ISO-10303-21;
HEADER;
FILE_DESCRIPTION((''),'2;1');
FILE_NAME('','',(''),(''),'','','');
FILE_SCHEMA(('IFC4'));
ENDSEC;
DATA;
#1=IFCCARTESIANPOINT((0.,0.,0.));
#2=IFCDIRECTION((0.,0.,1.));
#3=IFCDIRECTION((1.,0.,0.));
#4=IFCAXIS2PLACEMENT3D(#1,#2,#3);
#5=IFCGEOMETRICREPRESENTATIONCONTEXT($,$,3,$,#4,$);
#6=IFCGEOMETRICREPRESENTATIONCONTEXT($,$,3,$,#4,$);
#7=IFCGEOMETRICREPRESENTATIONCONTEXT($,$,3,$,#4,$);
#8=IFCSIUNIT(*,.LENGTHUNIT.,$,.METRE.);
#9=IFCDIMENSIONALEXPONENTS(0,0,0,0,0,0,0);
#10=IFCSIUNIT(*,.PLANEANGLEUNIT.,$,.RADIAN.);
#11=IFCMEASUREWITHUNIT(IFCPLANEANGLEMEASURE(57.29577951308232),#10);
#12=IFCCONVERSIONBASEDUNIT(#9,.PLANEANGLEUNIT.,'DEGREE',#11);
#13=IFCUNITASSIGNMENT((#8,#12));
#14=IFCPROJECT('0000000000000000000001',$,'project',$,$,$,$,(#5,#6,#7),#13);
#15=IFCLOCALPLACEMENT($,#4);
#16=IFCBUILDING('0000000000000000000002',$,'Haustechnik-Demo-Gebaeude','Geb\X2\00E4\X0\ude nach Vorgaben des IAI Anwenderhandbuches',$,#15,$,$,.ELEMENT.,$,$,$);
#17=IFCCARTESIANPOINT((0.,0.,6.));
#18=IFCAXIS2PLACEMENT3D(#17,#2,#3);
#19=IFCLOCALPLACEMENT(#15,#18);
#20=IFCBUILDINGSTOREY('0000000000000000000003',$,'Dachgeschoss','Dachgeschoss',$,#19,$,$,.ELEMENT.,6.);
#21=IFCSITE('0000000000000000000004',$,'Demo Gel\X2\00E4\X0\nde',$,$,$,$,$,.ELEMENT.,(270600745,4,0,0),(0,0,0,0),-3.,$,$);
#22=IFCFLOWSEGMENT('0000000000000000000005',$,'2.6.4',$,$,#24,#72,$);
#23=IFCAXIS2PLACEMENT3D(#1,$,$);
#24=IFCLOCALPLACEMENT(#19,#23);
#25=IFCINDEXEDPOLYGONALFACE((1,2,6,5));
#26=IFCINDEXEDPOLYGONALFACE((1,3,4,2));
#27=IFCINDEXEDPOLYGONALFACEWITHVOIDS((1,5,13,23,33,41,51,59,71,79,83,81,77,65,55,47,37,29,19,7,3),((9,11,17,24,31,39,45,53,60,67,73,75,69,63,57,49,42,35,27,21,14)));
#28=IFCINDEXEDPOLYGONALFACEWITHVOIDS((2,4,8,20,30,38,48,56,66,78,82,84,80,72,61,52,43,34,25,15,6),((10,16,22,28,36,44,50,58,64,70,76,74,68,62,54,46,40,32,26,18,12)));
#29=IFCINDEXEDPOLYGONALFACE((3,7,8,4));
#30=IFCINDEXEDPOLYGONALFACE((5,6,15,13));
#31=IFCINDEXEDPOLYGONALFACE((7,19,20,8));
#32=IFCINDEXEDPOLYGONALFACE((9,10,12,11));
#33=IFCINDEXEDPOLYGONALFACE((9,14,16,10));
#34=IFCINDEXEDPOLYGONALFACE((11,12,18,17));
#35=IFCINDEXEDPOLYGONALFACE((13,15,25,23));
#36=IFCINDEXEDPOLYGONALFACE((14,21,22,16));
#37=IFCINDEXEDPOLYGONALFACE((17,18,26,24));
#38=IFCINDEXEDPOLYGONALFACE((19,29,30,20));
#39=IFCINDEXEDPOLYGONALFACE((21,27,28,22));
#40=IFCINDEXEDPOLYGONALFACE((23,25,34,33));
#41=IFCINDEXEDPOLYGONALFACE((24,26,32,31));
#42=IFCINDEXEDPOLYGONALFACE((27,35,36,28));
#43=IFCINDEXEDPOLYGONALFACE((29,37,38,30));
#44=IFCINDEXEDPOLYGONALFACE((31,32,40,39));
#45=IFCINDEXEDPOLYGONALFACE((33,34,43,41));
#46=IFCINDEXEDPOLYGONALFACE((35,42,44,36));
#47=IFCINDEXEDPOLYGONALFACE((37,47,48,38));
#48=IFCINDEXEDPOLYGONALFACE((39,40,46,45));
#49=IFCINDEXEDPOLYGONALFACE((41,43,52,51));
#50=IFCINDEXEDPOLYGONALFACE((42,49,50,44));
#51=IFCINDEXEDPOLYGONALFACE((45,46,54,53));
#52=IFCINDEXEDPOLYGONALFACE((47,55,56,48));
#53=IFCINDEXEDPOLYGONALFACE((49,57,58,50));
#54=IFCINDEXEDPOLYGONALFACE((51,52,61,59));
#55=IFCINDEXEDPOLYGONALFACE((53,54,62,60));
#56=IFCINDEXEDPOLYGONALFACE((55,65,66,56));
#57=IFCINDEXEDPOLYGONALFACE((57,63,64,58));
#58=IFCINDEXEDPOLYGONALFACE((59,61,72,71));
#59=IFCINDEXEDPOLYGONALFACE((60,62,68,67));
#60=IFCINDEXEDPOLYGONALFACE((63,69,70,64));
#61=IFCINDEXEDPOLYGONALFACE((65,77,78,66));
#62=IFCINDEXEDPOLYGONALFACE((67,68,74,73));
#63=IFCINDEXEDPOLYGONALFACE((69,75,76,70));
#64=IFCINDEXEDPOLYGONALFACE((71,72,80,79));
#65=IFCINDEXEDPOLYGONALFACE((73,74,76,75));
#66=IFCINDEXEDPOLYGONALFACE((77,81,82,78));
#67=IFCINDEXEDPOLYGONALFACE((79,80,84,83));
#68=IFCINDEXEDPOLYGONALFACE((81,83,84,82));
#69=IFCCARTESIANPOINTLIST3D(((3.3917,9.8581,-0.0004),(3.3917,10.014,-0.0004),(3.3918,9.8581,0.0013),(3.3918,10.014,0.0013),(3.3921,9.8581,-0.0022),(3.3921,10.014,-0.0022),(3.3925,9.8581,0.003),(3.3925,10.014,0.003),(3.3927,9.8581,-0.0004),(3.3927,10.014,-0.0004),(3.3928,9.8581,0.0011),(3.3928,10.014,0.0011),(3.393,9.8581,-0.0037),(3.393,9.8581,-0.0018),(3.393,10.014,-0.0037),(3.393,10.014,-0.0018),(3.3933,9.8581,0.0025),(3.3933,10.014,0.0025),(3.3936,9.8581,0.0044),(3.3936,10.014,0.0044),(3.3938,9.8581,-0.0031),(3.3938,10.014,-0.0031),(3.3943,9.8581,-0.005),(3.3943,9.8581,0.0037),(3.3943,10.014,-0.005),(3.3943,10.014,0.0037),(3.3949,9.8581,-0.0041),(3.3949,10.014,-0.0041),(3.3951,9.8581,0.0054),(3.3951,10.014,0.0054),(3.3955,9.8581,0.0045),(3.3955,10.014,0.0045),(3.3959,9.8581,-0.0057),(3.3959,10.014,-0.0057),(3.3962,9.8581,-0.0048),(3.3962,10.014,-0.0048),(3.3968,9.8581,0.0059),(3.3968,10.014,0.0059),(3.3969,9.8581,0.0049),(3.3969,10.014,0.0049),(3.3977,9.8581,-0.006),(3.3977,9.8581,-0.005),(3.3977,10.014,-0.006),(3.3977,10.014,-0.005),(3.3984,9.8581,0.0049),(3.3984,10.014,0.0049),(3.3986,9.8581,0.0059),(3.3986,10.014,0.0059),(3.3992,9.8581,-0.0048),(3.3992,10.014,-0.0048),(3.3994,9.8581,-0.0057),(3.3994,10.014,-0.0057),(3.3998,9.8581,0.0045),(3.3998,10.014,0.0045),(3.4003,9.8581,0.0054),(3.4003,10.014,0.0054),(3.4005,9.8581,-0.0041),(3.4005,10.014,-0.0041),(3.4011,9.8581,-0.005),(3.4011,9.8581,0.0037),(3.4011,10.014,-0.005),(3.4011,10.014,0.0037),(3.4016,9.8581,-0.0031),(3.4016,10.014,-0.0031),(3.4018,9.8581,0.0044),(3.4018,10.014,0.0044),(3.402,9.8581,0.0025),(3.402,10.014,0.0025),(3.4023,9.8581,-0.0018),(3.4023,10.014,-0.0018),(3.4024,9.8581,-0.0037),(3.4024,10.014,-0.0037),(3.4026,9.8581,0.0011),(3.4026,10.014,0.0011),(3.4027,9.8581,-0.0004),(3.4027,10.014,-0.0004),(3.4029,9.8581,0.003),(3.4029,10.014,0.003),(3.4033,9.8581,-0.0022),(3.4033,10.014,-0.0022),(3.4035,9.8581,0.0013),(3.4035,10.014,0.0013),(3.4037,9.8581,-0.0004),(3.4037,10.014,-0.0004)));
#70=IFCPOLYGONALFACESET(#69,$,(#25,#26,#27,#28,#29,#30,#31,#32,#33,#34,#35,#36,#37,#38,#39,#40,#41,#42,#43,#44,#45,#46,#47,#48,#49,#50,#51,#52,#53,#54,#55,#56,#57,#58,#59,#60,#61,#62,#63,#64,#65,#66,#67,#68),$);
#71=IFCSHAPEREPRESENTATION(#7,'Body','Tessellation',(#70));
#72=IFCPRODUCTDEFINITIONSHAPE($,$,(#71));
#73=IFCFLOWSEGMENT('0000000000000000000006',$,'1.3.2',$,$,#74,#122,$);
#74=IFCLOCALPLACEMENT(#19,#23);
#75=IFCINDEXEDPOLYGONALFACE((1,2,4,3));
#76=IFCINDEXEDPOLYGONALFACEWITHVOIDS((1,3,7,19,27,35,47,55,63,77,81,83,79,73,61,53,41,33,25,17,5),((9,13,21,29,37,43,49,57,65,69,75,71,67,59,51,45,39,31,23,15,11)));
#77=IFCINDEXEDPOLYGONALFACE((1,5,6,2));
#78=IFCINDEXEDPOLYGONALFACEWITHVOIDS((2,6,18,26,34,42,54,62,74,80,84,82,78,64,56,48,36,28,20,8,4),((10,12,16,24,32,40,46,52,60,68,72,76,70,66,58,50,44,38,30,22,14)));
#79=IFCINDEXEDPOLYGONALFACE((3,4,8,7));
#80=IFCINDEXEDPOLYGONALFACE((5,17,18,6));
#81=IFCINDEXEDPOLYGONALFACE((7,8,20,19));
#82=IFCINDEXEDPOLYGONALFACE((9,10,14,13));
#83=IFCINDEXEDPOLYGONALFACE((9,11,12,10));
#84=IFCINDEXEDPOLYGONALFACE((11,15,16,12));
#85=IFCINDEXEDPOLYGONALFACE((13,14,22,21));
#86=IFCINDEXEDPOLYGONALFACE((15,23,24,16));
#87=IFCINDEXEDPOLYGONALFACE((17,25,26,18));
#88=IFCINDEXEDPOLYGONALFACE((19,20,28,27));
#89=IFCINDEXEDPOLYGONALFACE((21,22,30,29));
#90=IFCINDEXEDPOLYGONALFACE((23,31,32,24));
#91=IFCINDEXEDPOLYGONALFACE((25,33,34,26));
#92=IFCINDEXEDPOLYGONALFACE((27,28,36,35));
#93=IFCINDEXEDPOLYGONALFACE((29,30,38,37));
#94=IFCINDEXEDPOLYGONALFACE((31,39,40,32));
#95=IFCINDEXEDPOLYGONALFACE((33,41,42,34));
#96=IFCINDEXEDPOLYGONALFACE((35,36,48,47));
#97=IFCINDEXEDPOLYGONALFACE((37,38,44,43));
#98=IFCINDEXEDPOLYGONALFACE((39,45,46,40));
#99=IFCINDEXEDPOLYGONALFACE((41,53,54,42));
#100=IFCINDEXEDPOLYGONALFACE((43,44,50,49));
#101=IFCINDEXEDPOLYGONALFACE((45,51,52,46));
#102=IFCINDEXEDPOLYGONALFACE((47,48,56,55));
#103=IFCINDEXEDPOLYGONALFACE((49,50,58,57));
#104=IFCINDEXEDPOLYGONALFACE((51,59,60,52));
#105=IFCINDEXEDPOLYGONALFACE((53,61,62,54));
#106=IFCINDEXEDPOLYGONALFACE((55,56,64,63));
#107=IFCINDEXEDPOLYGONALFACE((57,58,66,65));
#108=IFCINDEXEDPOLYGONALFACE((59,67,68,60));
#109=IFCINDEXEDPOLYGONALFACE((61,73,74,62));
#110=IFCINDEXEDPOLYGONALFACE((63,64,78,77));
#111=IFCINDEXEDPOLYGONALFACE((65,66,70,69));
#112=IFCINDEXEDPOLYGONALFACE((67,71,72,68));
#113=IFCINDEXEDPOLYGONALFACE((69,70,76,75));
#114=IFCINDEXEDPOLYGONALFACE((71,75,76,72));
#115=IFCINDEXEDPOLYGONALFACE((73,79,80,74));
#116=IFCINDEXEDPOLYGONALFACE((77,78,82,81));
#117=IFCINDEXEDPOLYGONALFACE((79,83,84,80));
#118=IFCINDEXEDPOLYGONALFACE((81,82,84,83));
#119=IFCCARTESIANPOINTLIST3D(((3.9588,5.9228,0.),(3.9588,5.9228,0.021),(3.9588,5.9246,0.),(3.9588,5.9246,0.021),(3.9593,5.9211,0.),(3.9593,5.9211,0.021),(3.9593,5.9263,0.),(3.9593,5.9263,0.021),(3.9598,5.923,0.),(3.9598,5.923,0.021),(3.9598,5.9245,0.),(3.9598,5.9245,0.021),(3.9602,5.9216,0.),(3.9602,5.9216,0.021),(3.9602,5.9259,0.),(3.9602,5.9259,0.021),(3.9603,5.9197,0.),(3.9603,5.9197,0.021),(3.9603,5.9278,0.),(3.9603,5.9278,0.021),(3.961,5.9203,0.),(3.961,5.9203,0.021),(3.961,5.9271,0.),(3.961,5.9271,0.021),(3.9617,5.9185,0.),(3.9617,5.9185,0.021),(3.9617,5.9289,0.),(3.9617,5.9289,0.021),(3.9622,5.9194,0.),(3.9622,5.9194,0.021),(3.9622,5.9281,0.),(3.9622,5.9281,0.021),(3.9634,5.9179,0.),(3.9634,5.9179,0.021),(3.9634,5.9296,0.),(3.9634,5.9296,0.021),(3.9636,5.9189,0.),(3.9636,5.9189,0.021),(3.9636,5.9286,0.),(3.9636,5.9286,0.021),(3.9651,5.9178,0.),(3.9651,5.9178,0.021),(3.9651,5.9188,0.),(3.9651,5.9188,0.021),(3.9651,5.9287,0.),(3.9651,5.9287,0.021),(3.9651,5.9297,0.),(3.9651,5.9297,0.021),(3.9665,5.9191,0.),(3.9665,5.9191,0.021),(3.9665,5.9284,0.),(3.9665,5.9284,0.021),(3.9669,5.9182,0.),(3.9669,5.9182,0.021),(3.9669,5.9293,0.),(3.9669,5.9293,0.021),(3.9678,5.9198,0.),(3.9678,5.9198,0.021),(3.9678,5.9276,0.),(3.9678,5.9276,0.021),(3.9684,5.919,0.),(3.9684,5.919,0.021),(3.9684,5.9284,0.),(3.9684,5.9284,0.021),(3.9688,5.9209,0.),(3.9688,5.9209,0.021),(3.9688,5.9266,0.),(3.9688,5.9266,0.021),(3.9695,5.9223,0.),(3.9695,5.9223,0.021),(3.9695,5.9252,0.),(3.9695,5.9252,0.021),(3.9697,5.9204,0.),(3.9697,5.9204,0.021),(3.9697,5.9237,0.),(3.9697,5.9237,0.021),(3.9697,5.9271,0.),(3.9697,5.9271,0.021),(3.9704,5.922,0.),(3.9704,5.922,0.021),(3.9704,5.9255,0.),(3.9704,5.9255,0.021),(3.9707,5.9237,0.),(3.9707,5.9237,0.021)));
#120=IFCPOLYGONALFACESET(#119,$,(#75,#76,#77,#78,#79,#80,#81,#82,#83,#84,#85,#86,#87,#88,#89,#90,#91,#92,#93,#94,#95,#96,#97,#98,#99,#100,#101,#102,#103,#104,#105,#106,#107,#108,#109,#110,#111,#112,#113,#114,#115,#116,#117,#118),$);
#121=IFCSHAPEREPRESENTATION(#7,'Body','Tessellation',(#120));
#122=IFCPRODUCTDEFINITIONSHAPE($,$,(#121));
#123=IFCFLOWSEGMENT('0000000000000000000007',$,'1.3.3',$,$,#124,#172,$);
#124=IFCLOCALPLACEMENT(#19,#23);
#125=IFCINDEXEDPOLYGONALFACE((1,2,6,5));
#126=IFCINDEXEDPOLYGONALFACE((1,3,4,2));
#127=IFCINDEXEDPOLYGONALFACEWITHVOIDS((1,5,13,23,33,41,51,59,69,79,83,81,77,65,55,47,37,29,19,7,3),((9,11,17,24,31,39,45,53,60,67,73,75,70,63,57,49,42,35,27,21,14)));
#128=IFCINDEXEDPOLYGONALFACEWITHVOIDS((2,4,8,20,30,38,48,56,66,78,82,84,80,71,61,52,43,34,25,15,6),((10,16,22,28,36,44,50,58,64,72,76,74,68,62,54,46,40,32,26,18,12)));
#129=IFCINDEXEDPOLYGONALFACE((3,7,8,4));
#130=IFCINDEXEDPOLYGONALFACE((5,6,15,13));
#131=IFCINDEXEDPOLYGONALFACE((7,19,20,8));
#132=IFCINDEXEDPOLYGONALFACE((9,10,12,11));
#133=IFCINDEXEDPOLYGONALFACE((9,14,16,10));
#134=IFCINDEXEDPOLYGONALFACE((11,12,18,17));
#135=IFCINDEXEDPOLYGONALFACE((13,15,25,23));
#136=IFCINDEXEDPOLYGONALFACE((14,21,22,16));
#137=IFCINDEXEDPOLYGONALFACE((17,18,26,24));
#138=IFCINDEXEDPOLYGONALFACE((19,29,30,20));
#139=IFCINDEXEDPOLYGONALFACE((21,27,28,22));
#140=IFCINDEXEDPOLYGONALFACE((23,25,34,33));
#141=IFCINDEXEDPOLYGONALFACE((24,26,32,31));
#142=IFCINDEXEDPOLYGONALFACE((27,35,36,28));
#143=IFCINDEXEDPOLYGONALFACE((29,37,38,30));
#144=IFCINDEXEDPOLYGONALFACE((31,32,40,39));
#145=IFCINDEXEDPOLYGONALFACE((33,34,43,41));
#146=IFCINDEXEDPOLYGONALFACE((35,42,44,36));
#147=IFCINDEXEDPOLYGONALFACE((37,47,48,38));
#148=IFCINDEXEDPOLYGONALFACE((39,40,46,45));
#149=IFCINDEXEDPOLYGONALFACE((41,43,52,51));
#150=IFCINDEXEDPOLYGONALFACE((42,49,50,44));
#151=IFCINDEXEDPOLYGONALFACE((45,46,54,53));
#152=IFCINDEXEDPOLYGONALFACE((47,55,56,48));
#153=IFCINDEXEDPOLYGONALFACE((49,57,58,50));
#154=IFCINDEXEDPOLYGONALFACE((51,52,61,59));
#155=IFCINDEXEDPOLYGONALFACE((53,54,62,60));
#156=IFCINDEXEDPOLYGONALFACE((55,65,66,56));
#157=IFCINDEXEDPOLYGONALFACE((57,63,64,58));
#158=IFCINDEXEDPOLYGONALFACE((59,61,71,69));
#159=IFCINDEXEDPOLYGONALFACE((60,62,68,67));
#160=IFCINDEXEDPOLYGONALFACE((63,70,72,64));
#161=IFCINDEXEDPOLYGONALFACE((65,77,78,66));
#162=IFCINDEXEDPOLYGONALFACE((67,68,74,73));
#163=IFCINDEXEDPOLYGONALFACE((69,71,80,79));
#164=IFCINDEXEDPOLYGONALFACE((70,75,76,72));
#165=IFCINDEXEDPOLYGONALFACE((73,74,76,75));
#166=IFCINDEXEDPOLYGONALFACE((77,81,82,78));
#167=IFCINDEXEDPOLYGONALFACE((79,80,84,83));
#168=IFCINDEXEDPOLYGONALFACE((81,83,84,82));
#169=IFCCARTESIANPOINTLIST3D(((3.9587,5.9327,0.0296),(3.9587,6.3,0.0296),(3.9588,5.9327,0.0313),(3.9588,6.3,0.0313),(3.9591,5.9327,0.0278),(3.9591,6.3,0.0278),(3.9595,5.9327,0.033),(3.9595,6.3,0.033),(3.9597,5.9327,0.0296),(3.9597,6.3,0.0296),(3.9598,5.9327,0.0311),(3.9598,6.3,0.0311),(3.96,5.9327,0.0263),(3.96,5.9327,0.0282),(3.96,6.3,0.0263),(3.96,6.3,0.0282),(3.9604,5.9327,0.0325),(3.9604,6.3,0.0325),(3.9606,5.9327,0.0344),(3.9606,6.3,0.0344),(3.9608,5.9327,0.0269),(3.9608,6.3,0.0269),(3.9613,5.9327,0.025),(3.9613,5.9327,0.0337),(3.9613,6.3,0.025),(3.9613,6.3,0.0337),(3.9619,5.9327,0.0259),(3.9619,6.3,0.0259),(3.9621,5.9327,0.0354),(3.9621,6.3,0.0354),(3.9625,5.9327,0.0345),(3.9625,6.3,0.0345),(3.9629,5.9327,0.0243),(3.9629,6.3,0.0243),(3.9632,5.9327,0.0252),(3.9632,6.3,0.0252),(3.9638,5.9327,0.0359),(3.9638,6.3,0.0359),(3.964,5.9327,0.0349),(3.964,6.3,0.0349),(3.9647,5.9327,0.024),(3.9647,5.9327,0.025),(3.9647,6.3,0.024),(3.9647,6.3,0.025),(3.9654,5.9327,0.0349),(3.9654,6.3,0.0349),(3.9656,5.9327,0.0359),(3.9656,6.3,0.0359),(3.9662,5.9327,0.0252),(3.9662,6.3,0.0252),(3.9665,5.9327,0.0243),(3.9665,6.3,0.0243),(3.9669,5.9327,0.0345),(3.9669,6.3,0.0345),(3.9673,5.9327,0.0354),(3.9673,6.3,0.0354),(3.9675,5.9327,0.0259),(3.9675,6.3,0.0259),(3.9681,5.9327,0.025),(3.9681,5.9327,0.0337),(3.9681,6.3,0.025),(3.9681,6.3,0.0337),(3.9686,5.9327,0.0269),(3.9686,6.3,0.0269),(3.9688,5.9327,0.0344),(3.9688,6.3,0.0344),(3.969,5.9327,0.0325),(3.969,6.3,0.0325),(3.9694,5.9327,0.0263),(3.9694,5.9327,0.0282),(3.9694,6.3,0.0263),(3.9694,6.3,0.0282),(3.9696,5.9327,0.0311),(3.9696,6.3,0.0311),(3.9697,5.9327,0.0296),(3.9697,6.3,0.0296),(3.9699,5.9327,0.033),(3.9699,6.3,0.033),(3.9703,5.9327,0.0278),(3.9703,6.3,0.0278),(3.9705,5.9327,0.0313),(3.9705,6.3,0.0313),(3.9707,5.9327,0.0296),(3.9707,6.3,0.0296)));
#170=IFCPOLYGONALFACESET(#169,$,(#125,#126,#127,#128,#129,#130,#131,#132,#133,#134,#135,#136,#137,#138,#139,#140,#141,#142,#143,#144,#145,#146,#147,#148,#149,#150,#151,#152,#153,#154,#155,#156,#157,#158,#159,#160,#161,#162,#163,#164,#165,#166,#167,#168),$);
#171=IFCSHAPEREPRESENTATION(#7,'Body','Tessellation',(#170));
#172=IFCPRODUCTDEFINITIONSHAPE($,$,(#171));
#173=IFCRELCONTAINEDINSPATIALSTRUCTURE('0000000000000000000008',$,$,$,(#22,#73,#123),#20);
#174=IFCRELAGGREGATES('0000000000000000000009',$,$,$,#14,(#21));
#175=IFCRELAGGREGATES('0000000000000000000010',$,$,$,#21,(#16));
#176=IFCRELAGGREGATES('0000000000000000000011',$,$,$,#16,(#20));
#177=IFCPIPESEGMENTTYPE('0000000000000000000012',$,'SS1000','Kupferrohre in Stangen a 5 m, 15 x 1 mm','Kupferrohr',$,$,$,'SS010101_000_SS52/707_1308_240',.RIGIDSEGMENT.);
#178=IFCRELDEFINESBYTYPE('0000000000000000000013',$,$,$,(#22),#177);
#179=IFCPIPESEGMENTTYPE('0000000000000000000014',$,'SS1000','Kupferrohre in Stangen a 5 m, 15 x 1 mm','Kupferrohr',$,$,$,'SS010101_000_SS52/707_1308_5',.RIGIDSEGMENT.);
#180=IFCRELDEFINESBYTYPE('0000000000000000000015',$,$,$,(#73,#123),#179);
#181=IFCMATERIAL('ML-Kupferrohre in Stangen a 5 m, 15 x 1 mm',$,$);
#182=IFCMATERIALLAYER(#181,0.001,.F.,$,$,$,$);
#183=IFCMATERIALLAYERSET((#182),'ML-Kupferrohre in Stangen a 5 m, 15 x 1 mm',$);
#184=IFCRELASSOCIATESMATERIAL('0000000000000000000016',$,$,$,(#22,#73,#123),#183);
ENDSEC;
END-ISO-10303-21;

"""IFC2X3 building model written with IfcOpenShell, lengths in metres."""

from ifc_helpers import new_model, entity, si_unit, converted_unit, frame, origin_with_axes, origin_2d_with_axis, place, context, project, spatial, hollow_circle, extrude, material, layer, layer_set, layer_usage, type_object, element, save


model = new_model("IFC2X3")

# Units and contexts
context_of_model_1 = context(None, 3, world=origin_with_axes())
context_of_model_2 = context(None, 3, world=origin_with_axes())
context_of_model_3 = context(None, 3, world=origin_with_axes())
ifc_project = project(units=[si_unit("LENGTHUNIT", "METRE"), converted_unit("PLANEANGLEUNIT", "DEGREE", entity("IfcPlaneAngleMeasure", 57.29577951308232), si_unit("PLANEANGLEUNIT", "RADIAN"), dimensions=[0, 0, 0, 0, 0, 0, 0])], contexts=[context_of_model_1, context_of_model_2, context_of_model_3])

# Site, building, storey
site = spatial("IfcSite", under=ifc_project, Name="Demo Gelände", CompositionType="ELEMENT", RefLatitude=(270600745, 4, 0, 0), RefLongitude=(0, 0, 0, 0), RefElevation=-3.0)
building_placement = place(None, origin_with_axes())
building = spatial("IfcBuilding", under=site, at=building_placement, Name="Haustechnik-Demo-Gebaeude", Description="Gebäude nach Vorgaben des IAI Anwenderhandbuches", CompositionType="ELEMENT")
storey_placement = place(building_placement, frame((0.0, 0.0, 6.0), z_axis=(0.0, 0.0, 1.0), x_axis=(1.0, 0.0, 0.0)))
storey = spatial("IfcBuildingStorey", under=building, at=storey_placement, Name="Dachgeschoss", Description="Dachgeschoss", CompositionType="ELEMENT", Elevation=6.0)

# Flow segments
ifc_material = material(Name="ML-Kupferrohre in Stangen a 5 m, 15 x 1 mm")
ifc_layer = layer(ifc_material, 0.001, ventilated=False)
ifc_layer_set = layer_set([ifc_layer], Name="ML-Kupferrohre in Stangen a 5 m, 15 x 1 mm")
ifc_layer_usage = layer_usage(ifc_layer_set, "AXIS2", "POSITIVE", 0.0)
pipe_segment_type_1 = type_object("IfcPipeSegmentType", Name="SS1000", Description="Kupferrohre in Stangen a 5 m, 15 x 1 mm", ApplicableOccurrence="Kupferrohr", ElementType="SS010101_000_SS52/707_1308_240", PredefinedType="RIGIDSEGMENT")
flow_segment_1_placement = place(storey_placement, frame((3.3977, 10.014, 0.0), z_axis=(0.000021, -1.0, 0.0), x_axis=(0.0, 0.0, -1.0)))
element("IfcFlowSegment", 1, at=flow_segment_1_placement, inside=storey, type_object=pipe_segment_type_1, material=ifc_layer_usage, Name="2.6.4", context=context_of_model_3, shape_type="SweptSolid", body=[
    extrude(hollow_circle(Radius=0.006, WallThickness=0.001, at=origin_2d_with_axis()), origin_with_axes(), (0.0, 0.0, 1.0), 0.1559),
])
pipe_segment_type_2 = type_object("IfcPipeSegmentType", Name="SS1000", Description="Kupferrohre in Stangen a 5 m, 15 x 1 mm", ApplicableOccurrence="Kupferrohr", ElementType="SS010101_000_SS52/707_1308_5", PredefinedType="RIGIDSEGMENT")
flow_segment_2_placement = place(storey_placement, frame((3.9647, 5.9237, 0.0), z_axis=(0.0, 0.0, 1.0), x_axis=(1.0, 0.0, 0.0)))
element("IfcFlowSegment", 2, at=flow_segment_2_placement, inside=storey, type_object=pipe_segment_type_2, material=ifc_layer_usage, Name="1.3.2", context=context_of_model_3, shape_type="SweptSolid", body=[
    extrude(hollow_circle(Radius=0.006, WallThickness=0.001, at=origin_2d_with_axis()), origin_with_axes(), (0.0, 0.0, 1.0), 0.021),
])
flow_segment_3_placement = place(storey_placement, frame((3.9647, 5.9327, 0.03), z_axis=(0.0, 1.0, 0.0), x_axis=(0.0, 0.0, -1.0)))
element("IfcFlowSegment", 3, at=flow_segment_3_placement, inside=storey, type_object=pipe_segment_type_2, material=ifc_layer_usage, Name="1.3.3", context=context_of_model_3, shape_type="SweptSolid", body=[
    extrude(hollow_circle(Radius=0.006, WallThickness=0.001, at=origin_2d_with_axis()), origin_with_axes(), (0.0, 0.0, 1.0), 0.3673),
])

save(model, "model.ifc")
